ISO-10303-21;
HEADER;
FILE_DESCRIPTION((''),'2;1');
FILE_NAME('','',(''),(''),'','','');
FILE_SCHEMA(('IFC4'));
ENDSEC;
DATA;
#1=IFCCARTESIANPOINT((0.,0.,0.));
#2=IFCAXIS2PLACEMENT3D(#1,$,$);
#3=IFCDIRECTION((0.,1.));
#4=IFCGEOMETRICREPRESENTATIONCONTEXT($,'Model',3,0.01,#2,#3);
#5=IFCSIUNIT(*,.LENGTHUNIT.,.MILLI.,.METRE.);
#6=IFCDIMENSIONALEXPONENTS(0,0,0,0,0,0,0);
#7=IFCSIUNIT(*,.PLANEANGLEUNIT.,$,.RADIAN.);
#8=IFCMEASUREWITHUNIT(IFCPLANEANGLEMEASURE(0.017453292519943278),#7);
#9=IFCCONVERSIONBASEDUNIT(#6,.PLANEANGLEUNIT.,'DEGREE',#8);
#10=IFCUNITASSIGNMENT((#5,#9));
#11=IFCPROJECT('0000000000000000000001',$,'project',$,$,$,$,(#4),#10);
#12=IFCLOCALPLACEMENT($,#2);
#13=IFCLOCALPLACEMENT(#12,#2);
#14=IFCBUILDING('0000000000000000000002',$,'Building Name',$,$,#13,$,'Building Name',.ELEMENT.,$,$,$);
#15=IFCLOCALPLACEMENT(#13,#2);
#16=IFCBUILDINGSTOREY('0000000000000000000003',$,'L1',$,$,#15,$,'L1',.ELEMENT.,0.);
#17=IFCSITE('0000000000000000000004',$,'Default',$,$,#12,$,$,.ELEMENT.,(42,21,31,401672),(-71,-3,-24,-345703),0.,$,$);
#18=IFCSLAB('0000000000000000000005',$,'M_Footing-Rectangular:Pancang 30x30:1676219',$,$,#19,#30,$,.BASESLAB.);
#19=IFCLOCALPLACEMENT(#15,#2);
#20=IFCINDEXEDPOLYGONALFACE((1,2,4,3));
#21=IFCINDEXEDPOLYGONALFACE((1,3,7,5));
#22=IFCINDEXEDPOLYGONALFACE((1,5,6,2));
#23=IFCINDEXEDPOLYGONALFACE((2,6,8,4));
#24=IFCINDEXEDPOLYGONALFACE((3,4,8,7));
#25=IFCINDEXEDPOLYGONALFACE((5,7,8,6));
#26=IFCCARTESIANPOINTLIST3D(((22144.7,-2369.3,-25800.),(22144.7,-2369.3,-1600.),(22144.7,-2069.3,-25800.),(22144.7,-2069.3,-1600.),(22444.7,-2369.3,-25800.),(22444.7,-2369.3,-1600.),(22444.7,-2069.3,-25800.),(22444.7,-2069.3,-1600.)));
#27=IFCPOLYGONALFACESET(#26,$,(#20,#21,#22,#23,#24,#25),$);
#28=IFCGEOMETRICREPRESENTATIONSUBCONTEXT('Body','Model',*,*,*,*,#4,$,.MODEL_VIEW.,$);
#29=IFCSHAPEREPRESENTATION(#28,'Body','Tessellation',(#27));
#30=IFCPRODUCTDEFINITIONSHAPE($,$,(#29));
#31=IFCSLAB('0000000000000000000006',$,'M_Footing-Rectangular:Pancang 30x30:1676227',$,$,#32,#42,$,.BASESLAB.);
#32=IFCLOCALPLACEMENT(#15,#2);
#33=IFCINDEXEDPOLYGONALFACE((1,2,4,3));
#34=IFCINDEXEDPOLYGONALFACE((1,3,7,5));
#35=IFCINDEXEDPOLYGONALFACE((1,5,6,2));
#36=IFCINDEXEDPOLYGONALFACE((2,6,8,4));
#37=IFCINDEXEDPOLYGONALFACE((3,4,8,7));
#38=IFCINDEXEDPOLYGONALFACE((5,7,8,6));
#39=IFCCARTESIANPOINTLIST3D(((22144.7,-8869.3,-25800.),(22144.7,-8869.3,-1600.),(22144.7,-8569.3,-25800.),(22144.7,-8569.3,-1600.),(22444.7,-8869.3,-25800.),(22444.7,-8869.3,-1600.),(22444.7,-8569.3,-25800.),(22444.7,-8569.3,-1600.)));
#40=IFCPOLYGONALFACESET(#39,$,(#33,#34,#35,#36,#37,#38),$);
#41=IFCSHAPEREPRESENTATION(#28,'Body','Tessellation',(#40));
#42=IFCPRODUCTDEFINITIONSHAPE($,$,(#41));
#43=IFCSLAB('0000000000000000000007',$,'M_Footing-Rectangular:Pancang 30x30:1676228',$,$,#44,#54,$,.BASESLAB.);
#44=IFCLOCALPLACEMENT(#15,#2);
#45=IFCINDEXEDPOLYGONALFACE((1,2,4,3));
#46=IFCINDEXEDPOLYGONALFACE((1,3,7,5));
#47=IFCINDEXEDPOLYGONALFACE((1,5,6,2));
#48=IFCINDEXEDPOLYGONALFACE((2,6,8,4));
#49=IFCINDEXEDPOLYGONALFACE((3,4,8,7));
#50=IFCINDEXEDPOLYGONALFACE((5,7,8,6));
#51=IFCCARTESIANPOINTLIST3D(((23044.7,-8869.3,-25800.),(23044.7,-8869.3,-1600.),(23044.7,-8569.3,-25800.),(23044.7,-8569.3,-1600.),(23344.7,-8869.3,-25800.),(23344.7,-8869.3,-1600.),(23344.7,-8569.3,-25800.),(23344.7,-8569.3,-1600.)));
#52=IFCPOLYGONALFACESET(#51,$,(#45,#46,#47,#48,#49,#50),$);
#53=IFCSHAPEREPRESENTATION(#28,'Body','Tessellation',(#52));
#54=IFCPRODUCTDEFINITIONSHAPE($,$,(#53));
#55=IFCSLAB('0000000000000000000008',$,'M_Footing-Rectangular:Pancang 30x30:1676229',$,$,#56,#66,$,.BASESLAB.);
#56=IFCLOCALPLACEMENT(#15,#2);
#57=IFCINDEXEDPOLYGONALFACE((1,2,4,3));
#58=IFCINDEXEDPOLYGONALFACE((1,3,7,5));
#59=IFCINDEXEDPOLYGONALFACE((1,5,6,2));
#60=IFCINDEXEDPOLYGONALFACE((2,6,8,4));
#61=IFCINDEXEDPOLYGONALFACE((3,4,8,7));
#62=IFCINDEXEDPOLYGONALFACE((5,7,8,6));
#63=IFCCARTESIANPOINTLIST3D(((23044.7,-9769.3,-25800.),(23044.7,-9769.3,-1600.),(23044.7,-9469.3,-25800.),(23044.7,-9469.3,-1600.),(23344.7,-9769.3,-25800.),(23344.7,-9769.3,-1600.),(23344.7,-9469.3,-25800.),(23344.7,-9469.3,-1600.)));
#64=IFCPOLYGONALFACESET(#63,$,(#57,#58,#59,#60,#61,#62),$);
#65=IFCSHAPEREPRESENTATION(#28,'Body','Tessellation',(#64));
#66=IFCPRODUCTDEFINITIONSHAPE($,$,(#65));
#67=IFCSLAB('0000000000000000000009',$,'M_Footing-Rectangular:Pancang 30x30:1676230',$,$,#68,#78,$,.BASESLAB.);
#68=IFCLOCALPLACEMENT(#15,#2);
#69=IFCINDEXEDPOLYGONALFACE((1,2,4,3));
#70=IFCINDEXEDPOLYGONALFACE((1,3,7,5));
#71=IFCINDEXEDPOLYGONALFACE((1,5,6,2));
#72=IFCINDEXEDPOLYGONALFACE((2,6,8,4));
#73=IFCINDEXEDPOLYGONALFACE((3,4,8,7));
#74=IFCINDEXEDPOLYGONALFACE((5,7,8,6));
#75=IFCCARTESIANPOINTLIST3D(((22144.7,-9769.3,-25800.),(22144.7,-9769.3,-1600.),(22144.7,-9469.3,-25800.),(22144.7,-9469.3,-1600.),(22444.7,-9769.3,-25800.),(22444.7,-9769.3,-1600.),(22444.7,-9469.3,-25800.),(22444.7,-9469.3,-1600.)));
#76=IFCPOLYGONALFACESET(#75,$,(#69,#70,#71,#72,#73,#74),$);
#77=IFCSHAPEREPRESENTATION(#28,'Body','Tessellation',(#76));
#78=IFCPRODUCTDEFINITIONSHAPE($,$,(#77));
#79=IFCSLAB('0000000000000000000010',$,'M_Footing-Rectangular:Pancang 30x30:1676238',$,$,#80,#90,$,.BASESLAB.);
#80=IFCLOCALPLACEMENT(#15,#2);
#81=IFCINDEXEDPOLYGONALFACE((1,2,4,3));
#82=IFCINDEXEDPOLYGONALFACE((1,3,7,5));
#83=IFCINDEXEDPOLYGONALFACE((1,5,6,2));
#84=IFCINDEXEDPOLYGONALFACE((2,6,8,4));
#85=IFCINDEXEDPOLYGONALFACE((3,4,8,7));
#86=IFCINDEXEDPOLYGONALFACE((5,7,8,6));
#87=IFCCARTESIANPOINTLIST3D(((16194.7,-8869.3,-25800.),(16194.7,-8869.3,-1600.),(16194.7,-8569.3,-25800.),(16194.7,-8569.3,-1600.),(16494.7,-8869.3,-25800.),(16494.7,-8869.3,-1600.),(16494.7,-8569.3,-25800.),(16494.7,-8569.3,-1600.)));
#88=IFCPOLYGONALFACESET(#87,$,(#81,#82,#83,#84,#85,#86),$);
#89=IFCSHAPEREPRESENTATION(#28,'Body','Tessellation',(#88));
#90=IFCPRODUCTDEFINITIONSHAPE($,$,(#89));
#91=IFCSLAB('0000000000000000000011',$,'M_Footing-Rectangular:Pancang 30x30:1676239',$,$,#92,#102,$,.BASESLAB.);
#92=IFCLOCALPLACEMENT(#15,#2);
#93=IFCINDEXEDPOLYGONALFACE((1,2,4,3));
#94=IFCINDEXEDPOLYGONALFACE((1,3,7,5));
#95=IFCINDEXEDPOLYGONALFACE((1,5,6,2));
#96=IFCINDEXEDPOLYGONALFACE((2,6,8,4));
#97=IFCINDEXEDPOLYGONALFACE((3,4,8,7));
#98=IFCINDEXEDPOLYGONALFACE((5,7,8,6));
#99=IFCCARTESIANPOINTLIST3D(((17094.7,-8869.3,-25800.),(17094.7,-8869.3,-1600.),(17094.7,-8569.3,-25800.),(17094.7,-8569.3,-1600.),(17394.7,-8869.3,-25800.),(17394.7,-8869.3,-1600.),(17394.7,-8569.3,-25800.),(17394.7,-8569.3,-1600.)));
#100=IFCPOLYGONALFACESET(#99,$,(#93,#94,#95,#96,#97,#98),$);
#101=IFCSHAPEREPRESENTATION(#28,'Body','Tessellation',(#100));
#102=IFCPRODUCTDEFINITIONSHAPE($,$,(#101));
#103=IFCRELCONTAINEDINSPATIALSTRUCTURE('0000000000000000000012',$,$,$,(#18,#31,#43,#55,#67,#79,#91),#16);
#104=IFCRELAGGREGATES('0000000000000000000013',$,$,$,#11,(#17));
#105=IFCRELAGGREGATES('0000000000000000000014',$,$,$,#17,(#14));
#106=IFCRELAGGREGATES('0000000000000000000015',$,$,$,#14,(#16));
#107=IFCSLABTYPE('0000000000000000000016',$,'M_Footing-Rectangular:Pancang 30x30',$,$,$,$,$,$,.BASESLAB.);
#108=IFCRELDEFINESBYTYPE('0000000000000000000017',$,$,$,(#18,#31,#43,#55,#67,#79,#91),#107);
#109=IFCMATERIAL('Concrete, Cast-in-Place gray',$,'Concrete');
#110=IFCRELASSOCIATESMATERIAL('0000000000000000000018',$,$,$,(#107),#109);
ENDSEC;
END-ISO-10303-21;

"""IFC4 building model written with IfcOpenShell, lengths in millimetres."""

from ifc_helpers import new_model, entity, si_unit, converted_unit, direction, frame, origin, place, context, subcontext, project, spatial, indexed_curve, outline, extrude, material, type_object, element, save


model = new_model("IFC4")

# Units and contexts
model_context = context("Model", 3, precision=0.01, world=origin(), true_north=direction((0.0, 1.0)))
body_context = subcontext(model_context, "Body", "Model", "MODEL_VIEW")
ifc_project = project(units=[si_unit("LENGTHUNIT", "METRE", prefix="MILLI"), converted_unit("PLANEANGLEUNIT", "DEGREE", entity("IfcPlaneAngleMeasure", 0.017453292519943278), si_unit("PLANEANGLEUNIT", "RADIAN"), dimensions=[0, 0, 0, 0, 0, 0, 0])], contexts=[model_context])

# Site, building, storey
site_placement = place(None, origin())
site = spatial("IfcSite", under=ifc_project, at=site_placement, Name="Default", CompositionType="ELEMENT", RefLatitude=(42, 21, 31, 401672), RefLongitude=(-71, -3, -24, -345703), RefElevation=0.0)
building_placement = place(site_placement, origin())
building = spatial("IfcBuilding", under=site, at=building_placement, Name="Building Name", LongName="Building Name", CompositionType="ELEMENT")
storey_placement = place(building_placement, origin())
storey = spatial("IfcBuildingStorey", under=building, at=storey_placement, Name="L1", LongName="L1", CompositionType="ELEMENT", Elevation=0.0)

# Slabs
ifc_material = material(Name="Concrete, Cast-in-Place gray", Category="Concrete")
slab_type = type_object("IfcSlabType", Name="M_Footing-Rectangular:Pancang 30x30", PredefinedType="BASESLAB", material=ifc_material)
slab_1_placement = place(storey_placement, origin())
element("IfcSlab", 1, at=slab_1_placement, inside=storey, type_object=slab_type, Name="M_Footing-Rectangular:Pancang 30x30:1676219", PredefinedType="BASESLAB", context=body_context, shape_type="SweptSolid", body=[
    extrude(outline(indexed_curve([(-150.0, -150.0), (150.0, -150.0), (150.0, 150.0), (-150.0, 150.0), (-150.0, -150.0)], self_intersect=False)), frame((22294.7, -2219.3, -25800.0), z_axis=(0.0, 0.0, 1.0), x_axis=(-1.0, 0.0, 0.0)), (0.0, 0.0, 1.0), 24200.0),
])
slab_2_placement = place(storey_placement, origin())
element("IfcSlab", 2, at=slab_2_placement, inside=storey, type_object=slab_type, Name="M_Footing-Rectangular:Pancang 30x30:1676227", PredefinedType="BASESLAB", context=body_context, shape_type="SweptSolid", body=[
    extrude(outline(indexed_curve([(-150.0, -150.0), (150.0, -150.0), (150.0, 150.0), (-150.0, 150.0), (-150.0, -150.0)], self_intersect=False)), frame((22294.7, -8719.3, -25800.0), z_axis=(0.0, 0.0, 1.0), x_axis=(-1.0, 0.0, 0.0)), (0.0, 0.0, 1.0), 24200.0),
])
slab_3_placement = place(storey_placement, origin())
element("IfcSlab", 3, at=slab_3_placement, inside=storey, type_object=slab_type, Name="M_Footing-Rectangular:Pancang 30x30:1676228", PredefinedType="BASESLAB", context=body_context, shape_type="SweptSolid", body=[
    extrude(outline(indexed_curve([(-150.0, -150.0), (150.0, -150.0), (150.0, 150.0), (-150.0, 150.0), (-150.0, -150.0)], self_intersect=False)), frame((23194.7, -8719.3, -25800.0), z_axis=(0.0, 0.0, 1.0), x_axis=(-1.0, 0.0, 0.0)), (0.0, 0.0, 1.0), 24200.0),
])
slab_4_placement = place(storey_placement, origin())
element("IfcSlab", 4, at=slab_4_placement, inside=storey, type_object=slab_type, Name="M_Footing-Rectangular:Pancang 30x30:1676229", PredefinedType="BASESLAB", context=body_context, shape_type="SweptSolid", body=[
    extrude(outline(indexed_curve([(-150.0, -150.0), (150.0, -150.0), (150.0, 150.0), (-150.0, 150.0), (-150.0, -150.0)], self_intersect=False)), frame((23194.7, -9619.3, -25800.0), z_axis=(0.0, 0.0, 1.0), x_axis=(-1.0, 0.0, 0.0)), (0.0, 0.0, 1.0), 24200.0),
])
slab_5_placement = place(storey_placement, origin())
element("IfcSlab", 5, at=slab_5_placement, inside=storey, type_object=slab_type, Name="M_Footing-Rectangular:Pancang 30x30:1676230", PredefinedType="BASESLAB", context=body_context, shape_type="SweptSolid", body=[
    extrude(outline(indexed_curve([(-150.0, -150.0), (150.0, -150.0), (150.0, 150.0), (-150.0, 150.0), (-150.0, -150.0)], self_intersect=False)), frame((22294.7, -9619.3, -25800.0), z_axis=(0.0, 0.0, 1.0), x_axis=(-1.0, 0.0, 0.0)), (0.0, 0.0, 1.0), 24200.0),
])
slab_6_placement = place(storey_placement, origin())
element("IfcSlab", 6, at=slab_6_placement, inside=storey, type_object=slab_type, Name="M_Footing-Rectangular:Pancang 30x30:1676238", PredefinedType="BASESLAB", context=body_context, shape_type="SweptSolid", body=[
    extrude(outline(indexed_curve([(-150.0, -150.0), (150.0, -150.0), (150.0, 150.0), (-150.0, 150.0), (-150.0, -150.0)], self_intersect=False)), frame((16344.7, -8719.3, -25800.0), z_axis=(0.0, 0.0, 1.0), x_axis=(-1.0, 0.0, 0.0)), (0.0, 0.0, 1.0), 24200.0),
])
slab_7_placement = place(storey_placement, origin())
element("IfcSlab", 7, at=slab_7_placement, inside=storey, type_object=slab_type, Name="M_Footing-Rectangular:Pancang 30x30:1676239", PredefinedType="BASESLAB", context=body_context, shape_type="SweptSolid", body=[
    extrude(outline(indexed_curve([(-150.0, -150.0), (150.0, -150.0), (150.0, 150.0), (-150.0, 150.0), (-150.0, -150.0)], self_intersect=False)), frame((17244.7, -8719.3, -25800.0), z_axis=(0.0, 0.0, 1.0), x_axis=(-1.0, 0.0, 0.0)), (0.0, 0.0, 1.0), 24200.0),
])

save(model, "model.ifc")
